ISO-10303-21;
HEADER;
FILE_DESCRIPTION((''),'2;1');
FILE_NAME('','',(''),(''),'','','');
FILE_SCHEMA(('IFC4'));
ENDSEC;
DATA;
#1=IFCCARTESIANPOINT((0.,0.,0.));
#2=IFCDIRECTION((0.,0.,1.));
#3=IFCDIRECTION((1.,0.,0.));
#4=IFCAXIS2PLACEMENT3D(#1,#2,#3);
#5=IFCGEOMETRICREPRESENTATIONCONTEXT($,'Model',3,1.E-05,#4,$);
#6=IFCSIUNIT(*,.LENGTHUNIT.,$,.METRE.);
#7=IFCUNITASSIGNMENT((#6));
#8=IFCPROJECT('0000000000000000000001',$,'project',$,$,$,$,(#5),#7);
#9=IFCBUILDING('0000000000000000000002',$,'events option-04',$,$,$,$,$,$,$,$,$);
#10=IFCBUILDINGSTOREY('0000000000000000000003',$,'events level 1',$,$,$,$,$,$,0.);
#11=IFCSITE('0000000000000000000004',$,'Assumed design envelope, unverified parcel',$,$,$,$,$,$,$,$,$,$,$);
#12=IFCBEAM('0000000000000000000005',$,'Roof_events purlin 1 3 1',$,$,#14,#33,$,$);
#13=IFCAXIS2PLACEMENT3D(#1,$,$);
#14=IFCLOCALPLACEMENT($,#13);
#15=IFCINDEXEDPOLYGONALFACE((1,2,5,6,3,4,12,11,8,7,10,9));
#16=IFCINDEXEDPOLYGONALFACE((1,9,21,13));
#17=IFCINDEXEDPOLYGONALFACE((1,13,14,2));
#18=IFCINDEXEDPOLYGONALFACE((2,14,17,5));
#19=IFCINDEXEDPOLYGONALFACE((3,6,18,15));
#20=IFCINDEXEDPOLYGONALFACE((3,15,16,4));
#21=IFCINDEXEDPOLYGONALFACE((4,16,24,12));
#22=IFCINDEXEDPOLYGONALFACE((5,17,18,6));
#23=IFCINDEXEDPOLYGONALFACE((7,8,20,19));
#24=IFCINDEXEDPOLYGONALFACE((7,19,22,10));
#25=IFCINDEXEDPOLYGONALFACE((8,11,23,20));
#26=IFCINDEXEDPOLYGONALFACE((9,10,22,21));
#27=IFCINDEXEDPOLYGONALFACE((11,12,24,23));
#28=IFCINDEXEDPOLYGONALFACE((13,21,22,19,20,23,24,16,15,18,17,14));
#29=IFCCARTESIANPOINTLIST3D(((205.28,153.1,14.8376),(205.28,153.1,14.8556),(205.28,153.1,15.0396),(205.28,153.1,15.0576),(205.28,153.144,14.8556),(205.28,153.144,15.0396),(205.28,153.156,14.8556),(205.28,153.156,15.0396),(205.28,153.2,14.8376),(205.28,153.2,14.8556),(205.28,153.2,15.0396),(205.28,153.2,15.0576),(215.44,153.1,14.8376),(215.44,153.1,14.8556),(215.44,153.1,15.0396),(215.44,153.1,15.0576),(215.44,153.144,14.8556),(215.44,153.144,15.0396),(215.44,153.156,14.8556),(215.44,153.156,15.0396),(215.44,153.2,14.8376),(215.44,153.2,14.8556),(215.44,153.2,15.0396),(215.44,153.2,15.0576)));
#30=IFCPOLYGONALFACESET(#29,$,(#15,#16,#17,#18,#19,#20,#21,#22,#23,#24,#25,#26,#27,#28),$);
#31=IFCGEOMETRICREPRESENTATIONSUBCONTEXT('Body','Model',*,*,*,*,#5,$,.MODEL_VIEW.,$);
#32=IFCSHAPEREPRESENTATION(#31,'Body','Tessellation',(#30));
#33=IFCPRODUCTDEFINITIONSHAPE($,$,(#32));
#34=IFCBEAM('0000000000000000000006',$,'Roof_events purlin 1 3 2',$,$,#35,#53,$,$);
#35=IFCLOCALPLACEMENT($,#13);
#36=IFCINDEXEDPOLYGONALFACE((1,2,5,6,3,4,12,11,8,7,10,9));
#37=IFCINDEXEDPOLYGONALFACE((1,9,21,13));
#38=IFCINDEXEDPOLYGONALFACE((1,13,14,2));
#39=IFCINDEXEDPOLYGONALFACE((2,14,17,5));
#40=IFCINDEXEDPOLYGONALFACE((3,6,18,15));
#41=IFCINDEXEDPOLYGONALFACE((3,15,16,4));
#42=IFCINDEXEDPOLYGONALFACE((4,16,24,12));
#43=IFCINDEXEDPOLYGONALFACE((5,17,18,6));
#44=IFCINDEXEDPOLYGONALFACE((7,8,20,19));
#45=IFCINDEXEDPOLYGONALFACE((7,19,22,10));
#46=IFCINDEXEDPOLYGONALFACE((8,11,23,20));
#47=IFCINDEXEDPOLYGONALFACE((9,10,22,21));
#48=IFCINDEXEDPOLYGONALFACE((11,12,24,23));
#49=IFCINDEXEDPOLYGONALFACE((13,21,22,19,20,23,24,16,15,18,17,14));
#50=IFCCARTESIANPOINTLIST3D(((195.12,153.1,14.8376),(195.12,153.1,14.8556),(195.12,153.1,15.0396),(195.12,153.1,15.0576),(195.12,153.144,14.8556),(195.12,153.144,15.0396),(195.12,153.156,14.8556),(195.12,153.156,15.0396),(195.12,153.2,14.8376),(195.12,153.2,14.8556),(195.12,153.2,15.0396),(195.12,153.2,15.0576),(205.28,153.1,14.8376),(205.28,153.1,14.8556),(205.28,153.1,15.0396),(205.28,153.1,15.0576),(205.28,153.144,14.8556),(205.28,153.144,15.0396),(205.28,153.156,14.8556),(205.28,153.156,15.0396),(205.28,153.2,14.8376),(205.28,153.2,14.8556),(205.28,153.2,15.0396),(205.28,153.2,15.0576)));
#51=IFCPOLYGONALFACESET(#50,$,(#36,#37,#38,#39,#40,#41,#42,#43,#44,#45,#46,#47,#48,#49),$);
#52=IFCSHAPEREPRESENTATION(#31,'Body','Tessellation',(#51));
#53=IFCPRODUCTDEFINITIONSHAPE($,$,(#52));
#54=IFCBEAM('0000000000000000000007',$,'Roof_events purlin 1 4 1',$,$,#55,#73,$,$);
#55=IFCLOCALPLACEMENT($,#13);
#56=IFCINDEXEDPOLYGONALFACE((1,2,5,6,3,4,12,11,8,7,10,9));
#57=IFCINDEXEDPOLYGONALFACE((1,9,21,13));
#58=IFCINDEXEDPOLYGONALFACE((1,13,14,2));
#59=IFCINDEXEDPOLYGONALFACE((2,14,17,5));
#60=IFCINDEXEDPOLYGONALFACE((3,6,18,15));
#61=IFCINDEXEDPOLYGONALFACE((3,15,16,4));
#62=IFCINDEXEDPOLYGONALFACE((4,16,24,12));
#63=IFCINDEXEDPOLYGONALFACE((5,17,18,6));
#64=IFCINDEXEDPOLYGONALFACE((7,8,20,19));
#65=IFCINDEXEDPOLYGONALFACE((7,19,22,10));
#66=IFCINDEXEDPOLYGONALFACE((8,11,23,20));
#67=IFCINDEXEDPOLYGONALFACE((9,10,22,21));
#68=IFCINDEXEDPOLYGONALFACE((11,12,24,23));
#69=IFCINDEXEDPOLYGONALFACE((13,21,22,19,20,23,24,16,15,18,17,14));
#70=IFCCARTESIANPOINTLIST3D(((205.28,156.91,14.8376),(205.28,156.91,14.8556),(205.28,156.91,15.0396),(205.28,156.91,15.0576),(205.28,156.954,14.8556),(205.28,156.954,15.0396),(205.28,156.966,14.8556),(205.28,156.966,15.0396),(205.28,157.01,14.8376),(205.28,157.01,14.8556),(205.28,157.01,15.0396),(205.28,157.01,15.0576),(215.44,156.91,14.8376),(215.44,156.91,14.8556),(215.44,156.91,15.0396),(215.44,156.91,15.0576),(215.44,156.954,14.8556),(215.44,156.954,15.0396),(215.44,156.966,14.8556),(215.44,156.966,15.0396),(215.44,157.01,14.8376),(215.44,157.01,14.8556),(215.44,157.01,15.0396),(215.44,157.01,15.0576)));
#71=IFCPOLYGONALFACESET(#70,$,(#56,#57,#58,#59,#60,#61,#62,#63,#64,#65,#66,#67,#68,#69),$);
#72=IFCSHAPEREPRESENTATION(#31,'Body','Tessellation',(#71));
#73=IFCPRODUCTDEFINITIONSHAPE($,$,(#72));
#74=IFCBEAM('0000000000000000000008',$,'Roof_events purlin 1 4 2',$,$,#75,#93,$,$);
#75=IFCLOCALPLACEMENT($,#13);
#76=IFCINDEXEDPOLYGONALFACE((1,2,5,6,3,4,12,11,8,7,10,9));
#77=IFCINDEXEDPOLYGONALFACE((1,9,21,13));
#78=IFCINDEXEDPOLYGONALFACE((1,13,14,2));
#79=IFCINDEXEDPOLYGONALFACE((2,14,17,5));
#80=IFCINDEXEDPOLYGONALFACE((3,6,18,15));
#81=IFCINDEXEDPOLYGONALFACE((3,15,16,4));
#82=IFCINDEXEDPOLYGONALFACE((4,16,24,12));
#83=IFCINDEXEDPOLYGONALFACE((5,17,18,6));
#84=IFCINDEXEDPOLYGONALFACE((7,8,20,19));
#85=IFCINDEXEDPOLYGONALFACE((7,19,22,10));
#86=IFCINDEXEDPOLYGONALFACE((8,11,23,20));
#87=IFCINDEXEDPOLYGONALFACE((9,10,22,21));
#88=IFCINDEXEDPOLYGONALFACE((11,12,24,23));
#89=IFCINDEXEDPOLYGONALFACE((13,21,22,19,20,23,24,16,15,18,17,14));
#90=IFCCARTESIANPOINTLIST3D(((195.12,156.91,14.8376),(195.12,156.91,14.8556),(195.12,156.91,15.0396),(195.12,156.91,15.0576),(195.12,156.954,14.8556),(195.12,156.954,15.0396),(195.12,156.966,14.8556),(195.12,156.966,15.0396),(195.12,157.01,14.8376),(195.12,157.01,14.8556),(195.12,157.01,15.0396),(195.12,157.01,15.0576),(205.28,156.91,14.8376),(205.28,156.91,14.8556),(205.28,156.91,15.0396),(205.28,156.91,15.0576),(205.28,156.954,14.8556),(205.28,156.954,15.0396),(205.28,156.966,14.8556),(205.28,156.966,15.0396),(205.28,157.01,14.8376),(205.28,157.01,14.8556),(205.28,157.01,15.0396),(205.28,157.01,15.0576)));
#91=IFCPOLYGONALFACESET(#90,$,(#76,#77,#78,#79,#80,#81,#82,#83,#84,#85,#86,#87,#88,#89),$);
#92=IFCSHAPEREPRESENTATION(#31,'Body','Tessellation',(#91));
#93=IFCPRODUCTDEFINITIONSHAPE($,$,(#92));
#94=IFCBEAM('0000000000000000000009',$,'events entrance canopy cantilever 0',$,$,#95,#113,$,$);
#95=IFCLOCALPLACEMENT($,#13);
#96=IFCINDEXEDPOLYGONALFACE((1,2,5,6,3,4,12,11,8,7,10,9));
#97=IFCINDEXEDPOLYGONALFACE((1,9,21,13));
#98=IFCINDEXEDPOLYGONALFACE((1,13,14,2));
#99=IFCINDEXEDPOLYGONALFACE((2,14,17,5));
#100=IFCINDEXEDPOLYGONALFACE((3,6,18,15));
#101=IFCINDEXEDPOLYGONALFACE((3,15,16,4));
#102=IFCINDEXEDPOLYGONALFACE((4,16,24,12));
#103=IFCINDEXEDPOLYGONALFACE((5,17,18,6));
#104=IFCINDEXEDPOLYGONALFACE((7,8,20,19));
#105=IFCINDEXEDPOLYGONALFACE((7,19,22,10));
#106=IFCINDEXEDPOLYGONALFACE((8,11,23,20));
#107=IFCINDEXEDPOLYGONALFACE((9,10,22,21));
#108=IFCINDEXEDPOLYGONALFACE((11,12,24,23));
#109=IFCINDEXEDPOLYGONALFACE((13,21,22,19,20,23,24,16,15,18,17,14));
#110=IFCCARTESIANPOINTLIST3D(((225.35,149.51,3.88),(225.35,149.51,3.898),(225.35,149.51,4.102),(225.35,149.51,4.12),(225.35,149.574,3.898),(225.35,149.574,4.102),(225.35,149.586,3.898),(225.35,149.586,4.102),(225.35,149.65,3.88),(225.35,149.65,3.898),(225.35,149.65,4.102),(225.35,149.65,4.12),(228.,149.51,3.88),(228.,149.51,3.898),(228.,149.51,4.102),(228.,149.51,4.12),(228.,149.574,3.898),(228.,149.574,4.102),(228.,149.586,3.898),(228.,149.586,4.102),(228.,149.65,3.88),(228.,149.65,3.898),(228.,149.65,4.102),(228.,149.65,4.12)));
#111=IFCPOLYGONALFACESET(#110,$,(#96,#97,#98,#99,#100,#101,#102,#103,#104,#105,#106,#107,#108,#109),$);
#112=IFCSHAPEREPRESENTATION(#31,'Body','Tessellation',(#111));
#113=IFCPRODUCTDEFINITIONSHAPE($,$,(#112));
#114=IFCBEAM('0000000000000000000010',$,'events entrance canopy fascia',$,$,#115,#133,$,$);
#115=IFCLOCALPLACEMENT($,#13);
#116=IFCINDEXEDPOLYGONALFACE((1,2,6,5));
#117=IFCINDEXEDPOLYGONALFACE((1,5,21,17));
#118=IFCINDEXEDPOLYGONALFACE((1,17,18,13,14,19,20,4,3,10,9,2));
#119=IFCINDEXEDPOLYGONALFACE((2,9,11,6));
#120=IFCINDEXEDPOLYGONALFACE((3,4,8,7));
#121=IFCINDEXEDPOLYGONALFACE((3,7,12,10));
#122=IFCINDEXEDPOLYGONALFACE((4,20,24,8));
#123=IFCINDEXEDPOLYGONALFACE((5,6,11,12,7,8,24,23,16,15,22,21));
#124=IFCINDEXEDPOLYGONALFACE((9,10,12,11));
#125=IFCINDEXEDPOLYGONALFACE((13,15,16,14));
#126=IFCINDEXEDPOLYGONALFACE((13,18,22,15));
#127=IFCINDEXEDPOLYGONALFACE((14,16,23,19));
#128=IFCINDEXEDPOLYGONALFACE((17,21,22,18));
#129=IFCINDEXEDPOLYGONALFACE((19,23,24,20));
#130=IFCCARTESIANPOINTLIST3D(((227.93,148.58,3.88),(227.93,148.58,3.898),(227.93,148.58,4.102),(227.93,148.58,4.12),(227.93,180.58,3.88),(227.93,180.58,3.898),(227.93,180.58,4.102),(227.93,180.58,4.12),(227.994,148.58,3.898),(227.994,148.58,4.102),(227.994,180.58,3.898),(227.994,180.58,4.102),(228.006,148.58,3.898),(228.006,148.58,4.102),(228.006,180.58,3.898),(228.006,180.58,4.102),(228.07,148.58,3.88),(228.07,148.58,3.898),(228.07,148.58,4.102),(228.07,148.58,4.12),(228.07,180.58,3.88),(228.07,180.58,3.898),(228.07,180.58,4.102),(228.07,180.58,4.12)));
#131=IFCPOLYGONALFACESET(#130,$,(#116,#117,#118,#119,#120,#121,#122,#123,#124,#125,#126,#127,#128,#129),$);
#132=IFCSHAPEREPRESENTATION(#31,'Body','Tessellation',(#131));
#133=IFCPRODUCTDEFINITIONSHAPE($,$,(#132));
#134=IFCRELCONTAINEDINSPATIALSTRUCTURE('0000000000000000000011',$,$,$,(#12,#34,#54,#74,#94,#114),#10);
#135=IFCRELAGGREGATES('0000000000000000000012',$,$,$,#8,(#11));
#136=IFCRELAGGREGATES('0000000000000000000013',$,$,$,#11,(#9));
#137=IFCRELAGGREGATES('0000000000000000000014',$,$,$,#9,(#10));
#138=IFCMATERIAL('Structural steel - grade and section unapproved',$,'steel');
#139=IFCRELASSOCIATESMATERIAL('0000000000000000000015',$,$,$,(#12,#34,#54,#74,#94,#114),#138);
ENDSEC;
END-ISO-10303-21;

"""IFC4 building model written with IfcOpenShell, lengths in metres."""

from ifc_helpers import new_model, si_unit, frame, origin_with_axes, place, context, subcontext, project, spatial, i_section, extrude, material, element, save


model = new_model("IFC4")

# Units and contexts
model_context = context("Model", 3, precision=1e-05, world=origin_with_axes())
body_context = subcontext(model_context, "Body", "Model", "MODEL_VIEW")
ifc_project = project(units=[si_unit("LENGTHUNIT", "METRE")], contexts=[model_context])

# Site, building, storey
site = spatial("IfcSite", under=ifc_project, Name="Assumed design envelope, unverified parcel")
building = spatial("IfcBuilding", under=site, Name="events option-04")
storey = spatial("IfcBuildingStorey", under=building, Name="events level 1", Elevation=0.0)

# Beams
ifc_material = material(Name="Structural steel - grade and section unapproved", Category="steel")
for number, where, z_axis, x_axis, name in (
    (1, (215.44, 153.15, 14.9476), (-1.0, 0.0, 0.0), (0.0, -1.0, 0.0), "Roof_events purlin 1 3 1"),
    (2, (205.28, 153.15, 14.9476), (-1.0, 0.0, 0.0), (0.0, -1.0, 0.0), "Roof_events purlin 1 3 2"),
    (3, (215.44, 156.96, 14.9476), (-1.0, 0.0, 0.0), (0.0, -1.0, 0.0), "Roof_events purlin 1 4 1"),
    (4, (205.28, 156.96, 14.9476), (-1.0, 0.0, 0.0), (0.0, -1.0, 0.0), "Roof_events purlin 1 4 2"),
):
    element("IfcBeam", number, at=place(None, frame(where, z_axis=z_axis, x_axis=x_axis)), inside=storey, material=ifc_material, Name=name, context=body_context, shape_type="SweptSolid", body=[
        extrude(i_section(OverallWidth=0.1, OverallDepth=0.22, WebThickness=0.012, FlangeThickness=0.018, FilletRadius=0.0), origin_with_axes(), (0.0, 0.0, 1.0), 10.16),
    ])
beam_1_placement = place(None, frame((225.35, 149.58, 4.0), z_axis=(1.0, 0.0, 0.0), x_axis=(0.0, 1.0, 0.0)))
element("IfcBeam", 5, at=beam_1_placement, inside=storey, material=ifc_material, Name="events entrance canopy cantilever 0", context=body_context, shape_type="SweptSolid", body=[
    extrude(i_section(OverallWidth=0.14, OverallDepth=0.24, WebThickness=0.012, FlangeThickness=0.018, FilletRadius=0.0), origin_with_axes(), (0.0, 0.0, 1.0), 2.65),
])
beam_2_placement = place(None, frame((228.0, 148.58, 4.0), z_axis=(0.0, 1.0, 0.0), x_axis=(-1.0, 0.0, 0.0)))
element("IfcBeam", 6, at=beam_2_placement, inside=storey, material=ifc_material, Name="events entrance canopy fascia", context=body_context, shape_type="SweptSolid", body=[
    extrude(i_section(OverallWidth=0.14, OverallDepth=0.24, WebThickness=0.012, FlangeThickness=0.018, FilletRadius=0.0), origin_with_axes(), (0.0, 0.0, 1.0), 32.0),
])

save(model, "model.ifc")
